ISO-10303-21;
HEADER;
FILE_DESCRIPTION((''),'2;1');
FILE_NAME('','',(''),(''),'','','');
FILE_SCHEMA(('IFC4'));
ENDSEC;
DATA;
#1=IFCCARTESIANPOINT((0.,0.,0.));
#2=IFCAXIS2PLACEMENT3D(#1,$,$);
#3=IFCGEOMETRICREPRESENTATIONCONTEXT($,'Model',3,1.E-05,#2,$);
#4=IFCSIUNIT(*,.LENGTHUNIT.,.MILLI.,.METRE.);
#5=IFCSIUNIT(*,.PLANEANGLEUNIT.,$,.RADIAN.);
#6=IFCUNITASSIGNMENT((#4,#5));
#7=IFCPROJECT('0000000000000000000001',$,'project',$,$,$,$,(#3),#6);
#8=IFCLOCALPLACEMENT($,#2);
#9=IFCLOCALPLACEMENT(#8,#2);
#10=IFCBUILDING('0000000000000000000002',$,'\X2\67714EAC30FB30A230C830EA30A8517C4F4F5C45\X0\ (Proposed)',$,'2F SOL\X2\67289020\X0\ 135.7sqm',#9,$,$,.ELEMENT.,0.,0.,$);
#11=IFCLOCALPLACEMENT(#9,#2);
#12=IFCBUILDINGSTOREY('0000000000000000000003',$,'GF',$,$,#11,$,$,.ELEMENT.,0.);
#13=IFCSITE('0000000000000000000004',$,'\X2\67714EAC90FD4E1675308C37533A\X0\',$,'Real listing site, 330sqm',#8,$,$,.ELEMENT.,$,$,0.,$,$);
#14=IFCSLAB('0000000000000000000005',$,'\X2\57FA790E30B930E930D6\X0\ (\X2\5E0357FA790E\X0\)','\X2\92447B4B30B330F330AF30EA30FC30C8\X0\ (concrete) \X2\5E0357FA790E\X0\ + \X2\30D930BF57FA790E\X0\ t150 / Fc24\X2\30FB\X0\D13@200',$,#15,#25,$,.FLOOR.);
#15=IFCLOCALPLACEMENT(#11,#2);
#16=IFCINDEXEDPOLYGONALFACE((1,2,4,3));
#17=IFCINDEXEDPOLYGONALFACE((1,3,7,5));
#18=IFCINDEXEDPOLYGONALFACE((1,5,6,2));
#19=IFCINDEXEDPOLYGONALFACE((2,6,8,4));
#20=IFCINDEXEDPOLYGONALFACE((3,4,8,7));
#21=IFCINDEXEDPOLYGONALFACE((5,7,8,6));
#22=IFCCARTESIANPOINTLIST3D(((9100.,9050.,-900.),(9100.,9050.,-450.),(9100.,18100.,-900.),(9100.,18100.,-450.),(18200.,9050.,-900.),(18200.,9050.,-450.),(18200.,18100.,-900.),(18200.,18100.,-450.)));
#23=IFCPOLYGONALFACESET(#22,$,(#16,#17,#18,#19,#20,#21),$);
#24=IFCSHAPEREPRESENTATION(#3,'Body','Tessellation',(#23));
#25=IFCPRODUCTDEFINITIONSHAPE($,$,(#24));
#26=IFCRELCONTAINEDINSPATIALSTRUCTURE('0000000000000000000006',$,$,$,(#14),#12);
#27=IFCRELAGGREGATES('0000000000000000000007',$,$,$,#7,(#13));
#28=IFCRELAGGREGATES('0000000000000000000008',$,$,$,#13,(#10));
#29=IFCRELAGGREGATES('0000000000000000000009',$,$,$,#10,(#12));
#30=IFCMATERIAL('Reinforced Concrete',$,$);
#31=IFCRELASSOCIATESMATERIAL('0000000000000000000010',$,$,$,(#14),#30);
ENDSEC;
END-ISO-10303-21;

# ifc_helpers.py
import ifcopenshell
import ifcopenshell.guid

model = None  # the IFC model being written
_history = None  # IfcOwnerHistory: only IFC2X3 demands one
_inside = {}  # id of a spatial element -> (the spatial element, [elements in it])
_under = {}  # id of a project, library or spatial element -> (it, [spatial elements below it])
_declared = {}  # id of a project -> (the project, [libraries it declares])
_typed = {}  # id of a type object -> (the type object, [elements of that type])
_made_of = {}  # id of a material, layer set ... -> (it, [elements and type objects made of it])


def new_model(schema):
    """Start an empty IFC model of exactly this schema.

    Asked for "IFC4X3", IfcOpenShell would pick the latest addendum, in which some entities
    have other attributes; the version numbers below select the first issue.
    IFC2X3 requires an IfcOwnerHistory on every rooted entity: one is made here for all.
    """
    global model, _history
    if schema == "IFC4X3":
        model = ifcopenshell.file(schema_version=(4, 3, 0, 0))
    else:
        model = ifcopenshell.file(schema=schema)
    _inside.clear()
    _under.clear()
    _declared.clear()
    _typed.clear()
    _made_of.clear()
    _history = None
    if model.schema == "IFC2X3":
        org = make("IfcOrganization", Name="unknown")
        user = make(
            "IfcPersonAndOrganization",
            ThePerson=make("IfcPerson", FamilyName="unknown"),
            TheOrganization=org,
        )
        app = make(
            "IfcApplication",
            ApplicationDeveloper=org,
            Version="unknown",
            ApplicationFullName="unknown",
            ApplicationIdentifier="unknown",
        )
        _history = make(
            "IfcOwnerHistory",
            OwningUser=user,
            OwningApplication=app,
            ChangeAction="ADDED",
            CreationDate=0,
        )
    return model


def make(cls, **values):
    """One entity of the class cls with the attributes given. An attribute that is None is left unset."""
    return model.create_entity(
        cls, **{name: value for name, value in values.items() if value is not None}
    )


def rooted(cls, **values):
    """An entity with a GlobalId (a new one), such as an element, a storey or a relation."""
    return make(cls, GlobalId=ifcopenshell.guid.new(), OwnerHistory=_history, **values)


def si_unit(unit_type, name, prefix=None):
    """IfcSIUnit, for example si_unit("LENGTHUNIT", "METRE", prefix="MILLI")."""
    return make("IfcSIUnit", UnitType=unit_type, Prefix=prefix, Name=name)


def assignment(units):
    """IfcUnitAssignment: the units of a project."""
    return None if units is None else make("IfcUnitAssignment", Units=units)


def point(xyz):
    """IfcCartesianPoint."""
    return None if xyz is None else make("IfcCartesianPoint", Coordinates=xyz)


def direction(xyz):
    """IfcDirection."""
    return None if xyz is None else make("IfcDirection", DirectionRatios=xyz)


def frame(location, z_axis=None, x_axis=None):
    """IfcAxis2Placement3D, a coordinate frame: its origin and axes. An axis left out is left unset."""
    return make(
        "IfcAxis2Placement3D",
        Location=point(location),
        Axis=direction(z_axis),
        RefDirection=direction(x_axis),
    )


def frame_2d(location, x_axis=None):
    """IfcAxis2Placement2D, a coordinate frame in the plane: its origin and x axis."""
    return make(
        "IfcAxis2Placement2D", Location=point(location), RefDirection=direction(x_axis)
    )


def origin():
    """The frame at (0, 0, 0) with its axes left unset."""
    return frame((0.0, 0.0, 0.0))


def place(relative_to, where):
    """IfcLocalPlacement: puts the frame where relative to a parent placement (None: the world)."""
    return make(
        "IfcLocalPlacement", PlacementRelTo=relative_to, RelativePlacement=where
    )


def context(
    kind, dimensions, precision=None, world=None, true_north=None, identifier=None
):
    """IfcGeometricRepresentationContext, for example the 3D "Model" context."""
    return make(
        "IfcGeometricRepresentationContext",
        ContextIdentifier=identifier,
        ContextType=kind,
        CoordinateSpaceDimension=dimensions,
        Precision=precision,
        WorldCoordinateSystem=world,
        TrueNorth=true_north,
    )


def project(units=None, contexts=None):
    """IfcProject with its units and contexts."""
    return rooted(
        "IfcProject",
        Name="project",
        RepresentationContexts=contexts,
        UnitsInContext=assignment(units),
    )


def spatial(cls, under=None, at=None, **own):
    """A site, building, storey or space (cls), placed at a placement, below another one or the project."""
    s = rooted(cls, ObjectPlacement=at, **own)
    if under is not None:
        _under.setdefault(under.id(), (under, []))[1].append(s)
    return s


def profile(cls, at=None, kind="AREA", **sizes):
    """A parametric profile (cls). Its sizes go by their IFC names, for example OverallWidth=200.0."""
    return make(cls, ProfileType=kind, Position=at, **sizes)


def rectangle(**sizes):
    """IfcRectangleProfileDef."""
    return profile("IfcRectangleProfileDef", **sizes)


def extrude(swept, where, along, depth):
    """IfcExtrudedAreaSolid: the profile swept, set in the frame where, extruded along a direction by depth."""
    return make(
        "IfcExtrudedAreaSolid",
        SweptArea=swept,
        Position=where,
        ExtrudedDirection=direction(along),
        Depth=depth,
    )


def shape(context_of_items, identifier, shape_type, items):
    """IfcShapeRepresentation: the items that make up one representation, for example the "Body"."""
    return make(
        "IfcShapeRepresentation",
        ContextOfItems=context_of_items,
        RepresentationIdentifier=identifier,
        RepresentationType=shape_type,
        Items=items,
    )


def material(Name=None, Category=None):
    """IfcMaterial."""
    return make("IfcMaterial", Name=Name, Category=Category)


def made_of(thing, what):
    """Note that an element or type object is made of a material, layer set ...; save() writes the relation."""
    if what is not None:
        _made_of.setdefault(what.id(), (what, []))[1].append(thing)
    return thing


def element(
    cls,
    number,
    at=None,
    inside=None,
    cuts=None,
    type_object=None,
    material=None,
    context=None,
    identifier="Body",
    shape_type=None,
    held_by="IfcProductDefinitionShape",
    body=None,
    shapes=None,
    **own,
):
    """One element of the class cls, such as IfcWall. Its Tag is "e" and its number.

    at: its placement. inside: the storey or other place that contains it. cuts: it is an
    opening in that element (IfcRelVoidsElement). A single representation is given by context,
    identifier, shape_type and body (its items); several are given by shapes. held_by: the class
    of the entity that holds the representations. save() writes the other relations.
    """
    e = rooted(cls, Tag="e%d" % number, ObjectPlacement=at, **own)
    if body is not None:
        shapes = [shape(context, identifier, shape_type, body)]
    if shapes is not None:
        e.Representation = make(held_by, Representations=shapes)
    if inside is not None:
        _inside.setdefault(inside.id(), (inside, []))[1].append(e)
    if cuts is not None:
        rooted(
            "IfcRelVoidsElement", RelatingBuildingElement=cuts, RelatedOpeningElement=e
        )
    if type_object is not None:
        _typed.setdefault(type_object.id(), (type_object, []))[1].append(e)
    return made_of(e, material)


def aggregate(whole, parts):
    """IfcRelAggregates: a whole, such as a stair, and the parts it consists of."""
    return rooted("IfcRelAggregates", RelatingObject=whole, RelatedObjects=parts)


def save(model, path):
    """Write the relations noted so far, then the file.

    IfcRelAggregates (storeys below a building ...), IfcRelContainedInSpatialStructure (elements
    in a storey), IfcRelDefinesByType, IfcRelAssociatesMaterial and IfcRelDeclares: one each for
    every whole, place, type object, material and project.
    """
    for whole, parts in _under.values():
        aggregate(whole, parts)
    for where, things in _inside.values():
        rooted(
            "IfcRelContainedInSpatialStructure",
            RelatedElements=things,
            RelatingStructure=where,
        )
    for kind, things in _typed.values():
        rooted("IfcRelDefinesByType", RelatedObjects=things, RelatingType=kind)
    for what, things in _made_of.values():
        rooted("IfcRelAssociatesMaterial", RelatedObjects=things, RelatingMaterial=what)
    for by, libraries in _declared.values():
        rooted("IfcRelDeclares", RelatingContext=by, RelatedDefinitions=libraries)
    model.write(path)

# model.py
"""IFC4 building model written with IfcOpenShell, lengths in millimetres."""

from ifc_helpers import new_model, si_unit, frame, frame_2d, origin, place, context, project, spatial, rectangle, extrude, material, element, save


model = new_model("IFC4")

# Units and contexts
model_context = context("Model", 3, precision=1e-05, world=origin())
ifc_project = project(units=[si_unit("LENGTHUNIT", "METRE", prefix="MILLI"), si_unit("PLANEANGLEUNIT", "RADIAN")], contexts=[model_context])

# Site, building, storey
site_placement = place(None, origin())
site = spatial("IfcSite", under=ifc_project, at=site_placement, Name="東京都世田谷区", ObjectType="Real listing site, 330sqm", CompositionType="ELEMENT", RefElevation=0.0)
building_placement = place(site_placement, origin())
building = spatial("IfcBuilding", under=site, at=building_placement, Name="東京・アトリエ兼住居 (Proposed)", ObjectType="2F SOL木造 135.7sqm", CompositionType="ELEMENT", ElevationOfRefHeight=0.0, ElevationOfTerrain=0.0)
storey_placement = place(building_placement, origin())
storey = spatial("IfcBuildingStorey", under=building, at=storey_placement, Name="GF", CompositionType="ELEMENT", Elevation=0.0)

# Slab
ifc_material_1 = material(Name="Reinforced Concrete")
slab_1_placement = place(storey_placement, frame((4550.0, 4525.0, -450.0)))
element("IfcSlab", 1, at=slab_1_placement, inside=storey, material=ifc_material_1, Name="基礎スラブ (布基礎)", Description="鉄筋コンクリート (concrete) 布基礎 + ベタ基礎 t150 / Fc24・D13@200", PredefinedType="FLOOR", context=model_context, shape_type="SweptSolid", body=[
    extrude(rectangle(XDim=9100.0, YDim=9050.0, at=frame_2d((4550.0, 4525.0))), frame((4550.0, 4525.0, -450.0)), (0.0, 0.0, 1.0), 450.0),
])

save(model, "model.ifc")
